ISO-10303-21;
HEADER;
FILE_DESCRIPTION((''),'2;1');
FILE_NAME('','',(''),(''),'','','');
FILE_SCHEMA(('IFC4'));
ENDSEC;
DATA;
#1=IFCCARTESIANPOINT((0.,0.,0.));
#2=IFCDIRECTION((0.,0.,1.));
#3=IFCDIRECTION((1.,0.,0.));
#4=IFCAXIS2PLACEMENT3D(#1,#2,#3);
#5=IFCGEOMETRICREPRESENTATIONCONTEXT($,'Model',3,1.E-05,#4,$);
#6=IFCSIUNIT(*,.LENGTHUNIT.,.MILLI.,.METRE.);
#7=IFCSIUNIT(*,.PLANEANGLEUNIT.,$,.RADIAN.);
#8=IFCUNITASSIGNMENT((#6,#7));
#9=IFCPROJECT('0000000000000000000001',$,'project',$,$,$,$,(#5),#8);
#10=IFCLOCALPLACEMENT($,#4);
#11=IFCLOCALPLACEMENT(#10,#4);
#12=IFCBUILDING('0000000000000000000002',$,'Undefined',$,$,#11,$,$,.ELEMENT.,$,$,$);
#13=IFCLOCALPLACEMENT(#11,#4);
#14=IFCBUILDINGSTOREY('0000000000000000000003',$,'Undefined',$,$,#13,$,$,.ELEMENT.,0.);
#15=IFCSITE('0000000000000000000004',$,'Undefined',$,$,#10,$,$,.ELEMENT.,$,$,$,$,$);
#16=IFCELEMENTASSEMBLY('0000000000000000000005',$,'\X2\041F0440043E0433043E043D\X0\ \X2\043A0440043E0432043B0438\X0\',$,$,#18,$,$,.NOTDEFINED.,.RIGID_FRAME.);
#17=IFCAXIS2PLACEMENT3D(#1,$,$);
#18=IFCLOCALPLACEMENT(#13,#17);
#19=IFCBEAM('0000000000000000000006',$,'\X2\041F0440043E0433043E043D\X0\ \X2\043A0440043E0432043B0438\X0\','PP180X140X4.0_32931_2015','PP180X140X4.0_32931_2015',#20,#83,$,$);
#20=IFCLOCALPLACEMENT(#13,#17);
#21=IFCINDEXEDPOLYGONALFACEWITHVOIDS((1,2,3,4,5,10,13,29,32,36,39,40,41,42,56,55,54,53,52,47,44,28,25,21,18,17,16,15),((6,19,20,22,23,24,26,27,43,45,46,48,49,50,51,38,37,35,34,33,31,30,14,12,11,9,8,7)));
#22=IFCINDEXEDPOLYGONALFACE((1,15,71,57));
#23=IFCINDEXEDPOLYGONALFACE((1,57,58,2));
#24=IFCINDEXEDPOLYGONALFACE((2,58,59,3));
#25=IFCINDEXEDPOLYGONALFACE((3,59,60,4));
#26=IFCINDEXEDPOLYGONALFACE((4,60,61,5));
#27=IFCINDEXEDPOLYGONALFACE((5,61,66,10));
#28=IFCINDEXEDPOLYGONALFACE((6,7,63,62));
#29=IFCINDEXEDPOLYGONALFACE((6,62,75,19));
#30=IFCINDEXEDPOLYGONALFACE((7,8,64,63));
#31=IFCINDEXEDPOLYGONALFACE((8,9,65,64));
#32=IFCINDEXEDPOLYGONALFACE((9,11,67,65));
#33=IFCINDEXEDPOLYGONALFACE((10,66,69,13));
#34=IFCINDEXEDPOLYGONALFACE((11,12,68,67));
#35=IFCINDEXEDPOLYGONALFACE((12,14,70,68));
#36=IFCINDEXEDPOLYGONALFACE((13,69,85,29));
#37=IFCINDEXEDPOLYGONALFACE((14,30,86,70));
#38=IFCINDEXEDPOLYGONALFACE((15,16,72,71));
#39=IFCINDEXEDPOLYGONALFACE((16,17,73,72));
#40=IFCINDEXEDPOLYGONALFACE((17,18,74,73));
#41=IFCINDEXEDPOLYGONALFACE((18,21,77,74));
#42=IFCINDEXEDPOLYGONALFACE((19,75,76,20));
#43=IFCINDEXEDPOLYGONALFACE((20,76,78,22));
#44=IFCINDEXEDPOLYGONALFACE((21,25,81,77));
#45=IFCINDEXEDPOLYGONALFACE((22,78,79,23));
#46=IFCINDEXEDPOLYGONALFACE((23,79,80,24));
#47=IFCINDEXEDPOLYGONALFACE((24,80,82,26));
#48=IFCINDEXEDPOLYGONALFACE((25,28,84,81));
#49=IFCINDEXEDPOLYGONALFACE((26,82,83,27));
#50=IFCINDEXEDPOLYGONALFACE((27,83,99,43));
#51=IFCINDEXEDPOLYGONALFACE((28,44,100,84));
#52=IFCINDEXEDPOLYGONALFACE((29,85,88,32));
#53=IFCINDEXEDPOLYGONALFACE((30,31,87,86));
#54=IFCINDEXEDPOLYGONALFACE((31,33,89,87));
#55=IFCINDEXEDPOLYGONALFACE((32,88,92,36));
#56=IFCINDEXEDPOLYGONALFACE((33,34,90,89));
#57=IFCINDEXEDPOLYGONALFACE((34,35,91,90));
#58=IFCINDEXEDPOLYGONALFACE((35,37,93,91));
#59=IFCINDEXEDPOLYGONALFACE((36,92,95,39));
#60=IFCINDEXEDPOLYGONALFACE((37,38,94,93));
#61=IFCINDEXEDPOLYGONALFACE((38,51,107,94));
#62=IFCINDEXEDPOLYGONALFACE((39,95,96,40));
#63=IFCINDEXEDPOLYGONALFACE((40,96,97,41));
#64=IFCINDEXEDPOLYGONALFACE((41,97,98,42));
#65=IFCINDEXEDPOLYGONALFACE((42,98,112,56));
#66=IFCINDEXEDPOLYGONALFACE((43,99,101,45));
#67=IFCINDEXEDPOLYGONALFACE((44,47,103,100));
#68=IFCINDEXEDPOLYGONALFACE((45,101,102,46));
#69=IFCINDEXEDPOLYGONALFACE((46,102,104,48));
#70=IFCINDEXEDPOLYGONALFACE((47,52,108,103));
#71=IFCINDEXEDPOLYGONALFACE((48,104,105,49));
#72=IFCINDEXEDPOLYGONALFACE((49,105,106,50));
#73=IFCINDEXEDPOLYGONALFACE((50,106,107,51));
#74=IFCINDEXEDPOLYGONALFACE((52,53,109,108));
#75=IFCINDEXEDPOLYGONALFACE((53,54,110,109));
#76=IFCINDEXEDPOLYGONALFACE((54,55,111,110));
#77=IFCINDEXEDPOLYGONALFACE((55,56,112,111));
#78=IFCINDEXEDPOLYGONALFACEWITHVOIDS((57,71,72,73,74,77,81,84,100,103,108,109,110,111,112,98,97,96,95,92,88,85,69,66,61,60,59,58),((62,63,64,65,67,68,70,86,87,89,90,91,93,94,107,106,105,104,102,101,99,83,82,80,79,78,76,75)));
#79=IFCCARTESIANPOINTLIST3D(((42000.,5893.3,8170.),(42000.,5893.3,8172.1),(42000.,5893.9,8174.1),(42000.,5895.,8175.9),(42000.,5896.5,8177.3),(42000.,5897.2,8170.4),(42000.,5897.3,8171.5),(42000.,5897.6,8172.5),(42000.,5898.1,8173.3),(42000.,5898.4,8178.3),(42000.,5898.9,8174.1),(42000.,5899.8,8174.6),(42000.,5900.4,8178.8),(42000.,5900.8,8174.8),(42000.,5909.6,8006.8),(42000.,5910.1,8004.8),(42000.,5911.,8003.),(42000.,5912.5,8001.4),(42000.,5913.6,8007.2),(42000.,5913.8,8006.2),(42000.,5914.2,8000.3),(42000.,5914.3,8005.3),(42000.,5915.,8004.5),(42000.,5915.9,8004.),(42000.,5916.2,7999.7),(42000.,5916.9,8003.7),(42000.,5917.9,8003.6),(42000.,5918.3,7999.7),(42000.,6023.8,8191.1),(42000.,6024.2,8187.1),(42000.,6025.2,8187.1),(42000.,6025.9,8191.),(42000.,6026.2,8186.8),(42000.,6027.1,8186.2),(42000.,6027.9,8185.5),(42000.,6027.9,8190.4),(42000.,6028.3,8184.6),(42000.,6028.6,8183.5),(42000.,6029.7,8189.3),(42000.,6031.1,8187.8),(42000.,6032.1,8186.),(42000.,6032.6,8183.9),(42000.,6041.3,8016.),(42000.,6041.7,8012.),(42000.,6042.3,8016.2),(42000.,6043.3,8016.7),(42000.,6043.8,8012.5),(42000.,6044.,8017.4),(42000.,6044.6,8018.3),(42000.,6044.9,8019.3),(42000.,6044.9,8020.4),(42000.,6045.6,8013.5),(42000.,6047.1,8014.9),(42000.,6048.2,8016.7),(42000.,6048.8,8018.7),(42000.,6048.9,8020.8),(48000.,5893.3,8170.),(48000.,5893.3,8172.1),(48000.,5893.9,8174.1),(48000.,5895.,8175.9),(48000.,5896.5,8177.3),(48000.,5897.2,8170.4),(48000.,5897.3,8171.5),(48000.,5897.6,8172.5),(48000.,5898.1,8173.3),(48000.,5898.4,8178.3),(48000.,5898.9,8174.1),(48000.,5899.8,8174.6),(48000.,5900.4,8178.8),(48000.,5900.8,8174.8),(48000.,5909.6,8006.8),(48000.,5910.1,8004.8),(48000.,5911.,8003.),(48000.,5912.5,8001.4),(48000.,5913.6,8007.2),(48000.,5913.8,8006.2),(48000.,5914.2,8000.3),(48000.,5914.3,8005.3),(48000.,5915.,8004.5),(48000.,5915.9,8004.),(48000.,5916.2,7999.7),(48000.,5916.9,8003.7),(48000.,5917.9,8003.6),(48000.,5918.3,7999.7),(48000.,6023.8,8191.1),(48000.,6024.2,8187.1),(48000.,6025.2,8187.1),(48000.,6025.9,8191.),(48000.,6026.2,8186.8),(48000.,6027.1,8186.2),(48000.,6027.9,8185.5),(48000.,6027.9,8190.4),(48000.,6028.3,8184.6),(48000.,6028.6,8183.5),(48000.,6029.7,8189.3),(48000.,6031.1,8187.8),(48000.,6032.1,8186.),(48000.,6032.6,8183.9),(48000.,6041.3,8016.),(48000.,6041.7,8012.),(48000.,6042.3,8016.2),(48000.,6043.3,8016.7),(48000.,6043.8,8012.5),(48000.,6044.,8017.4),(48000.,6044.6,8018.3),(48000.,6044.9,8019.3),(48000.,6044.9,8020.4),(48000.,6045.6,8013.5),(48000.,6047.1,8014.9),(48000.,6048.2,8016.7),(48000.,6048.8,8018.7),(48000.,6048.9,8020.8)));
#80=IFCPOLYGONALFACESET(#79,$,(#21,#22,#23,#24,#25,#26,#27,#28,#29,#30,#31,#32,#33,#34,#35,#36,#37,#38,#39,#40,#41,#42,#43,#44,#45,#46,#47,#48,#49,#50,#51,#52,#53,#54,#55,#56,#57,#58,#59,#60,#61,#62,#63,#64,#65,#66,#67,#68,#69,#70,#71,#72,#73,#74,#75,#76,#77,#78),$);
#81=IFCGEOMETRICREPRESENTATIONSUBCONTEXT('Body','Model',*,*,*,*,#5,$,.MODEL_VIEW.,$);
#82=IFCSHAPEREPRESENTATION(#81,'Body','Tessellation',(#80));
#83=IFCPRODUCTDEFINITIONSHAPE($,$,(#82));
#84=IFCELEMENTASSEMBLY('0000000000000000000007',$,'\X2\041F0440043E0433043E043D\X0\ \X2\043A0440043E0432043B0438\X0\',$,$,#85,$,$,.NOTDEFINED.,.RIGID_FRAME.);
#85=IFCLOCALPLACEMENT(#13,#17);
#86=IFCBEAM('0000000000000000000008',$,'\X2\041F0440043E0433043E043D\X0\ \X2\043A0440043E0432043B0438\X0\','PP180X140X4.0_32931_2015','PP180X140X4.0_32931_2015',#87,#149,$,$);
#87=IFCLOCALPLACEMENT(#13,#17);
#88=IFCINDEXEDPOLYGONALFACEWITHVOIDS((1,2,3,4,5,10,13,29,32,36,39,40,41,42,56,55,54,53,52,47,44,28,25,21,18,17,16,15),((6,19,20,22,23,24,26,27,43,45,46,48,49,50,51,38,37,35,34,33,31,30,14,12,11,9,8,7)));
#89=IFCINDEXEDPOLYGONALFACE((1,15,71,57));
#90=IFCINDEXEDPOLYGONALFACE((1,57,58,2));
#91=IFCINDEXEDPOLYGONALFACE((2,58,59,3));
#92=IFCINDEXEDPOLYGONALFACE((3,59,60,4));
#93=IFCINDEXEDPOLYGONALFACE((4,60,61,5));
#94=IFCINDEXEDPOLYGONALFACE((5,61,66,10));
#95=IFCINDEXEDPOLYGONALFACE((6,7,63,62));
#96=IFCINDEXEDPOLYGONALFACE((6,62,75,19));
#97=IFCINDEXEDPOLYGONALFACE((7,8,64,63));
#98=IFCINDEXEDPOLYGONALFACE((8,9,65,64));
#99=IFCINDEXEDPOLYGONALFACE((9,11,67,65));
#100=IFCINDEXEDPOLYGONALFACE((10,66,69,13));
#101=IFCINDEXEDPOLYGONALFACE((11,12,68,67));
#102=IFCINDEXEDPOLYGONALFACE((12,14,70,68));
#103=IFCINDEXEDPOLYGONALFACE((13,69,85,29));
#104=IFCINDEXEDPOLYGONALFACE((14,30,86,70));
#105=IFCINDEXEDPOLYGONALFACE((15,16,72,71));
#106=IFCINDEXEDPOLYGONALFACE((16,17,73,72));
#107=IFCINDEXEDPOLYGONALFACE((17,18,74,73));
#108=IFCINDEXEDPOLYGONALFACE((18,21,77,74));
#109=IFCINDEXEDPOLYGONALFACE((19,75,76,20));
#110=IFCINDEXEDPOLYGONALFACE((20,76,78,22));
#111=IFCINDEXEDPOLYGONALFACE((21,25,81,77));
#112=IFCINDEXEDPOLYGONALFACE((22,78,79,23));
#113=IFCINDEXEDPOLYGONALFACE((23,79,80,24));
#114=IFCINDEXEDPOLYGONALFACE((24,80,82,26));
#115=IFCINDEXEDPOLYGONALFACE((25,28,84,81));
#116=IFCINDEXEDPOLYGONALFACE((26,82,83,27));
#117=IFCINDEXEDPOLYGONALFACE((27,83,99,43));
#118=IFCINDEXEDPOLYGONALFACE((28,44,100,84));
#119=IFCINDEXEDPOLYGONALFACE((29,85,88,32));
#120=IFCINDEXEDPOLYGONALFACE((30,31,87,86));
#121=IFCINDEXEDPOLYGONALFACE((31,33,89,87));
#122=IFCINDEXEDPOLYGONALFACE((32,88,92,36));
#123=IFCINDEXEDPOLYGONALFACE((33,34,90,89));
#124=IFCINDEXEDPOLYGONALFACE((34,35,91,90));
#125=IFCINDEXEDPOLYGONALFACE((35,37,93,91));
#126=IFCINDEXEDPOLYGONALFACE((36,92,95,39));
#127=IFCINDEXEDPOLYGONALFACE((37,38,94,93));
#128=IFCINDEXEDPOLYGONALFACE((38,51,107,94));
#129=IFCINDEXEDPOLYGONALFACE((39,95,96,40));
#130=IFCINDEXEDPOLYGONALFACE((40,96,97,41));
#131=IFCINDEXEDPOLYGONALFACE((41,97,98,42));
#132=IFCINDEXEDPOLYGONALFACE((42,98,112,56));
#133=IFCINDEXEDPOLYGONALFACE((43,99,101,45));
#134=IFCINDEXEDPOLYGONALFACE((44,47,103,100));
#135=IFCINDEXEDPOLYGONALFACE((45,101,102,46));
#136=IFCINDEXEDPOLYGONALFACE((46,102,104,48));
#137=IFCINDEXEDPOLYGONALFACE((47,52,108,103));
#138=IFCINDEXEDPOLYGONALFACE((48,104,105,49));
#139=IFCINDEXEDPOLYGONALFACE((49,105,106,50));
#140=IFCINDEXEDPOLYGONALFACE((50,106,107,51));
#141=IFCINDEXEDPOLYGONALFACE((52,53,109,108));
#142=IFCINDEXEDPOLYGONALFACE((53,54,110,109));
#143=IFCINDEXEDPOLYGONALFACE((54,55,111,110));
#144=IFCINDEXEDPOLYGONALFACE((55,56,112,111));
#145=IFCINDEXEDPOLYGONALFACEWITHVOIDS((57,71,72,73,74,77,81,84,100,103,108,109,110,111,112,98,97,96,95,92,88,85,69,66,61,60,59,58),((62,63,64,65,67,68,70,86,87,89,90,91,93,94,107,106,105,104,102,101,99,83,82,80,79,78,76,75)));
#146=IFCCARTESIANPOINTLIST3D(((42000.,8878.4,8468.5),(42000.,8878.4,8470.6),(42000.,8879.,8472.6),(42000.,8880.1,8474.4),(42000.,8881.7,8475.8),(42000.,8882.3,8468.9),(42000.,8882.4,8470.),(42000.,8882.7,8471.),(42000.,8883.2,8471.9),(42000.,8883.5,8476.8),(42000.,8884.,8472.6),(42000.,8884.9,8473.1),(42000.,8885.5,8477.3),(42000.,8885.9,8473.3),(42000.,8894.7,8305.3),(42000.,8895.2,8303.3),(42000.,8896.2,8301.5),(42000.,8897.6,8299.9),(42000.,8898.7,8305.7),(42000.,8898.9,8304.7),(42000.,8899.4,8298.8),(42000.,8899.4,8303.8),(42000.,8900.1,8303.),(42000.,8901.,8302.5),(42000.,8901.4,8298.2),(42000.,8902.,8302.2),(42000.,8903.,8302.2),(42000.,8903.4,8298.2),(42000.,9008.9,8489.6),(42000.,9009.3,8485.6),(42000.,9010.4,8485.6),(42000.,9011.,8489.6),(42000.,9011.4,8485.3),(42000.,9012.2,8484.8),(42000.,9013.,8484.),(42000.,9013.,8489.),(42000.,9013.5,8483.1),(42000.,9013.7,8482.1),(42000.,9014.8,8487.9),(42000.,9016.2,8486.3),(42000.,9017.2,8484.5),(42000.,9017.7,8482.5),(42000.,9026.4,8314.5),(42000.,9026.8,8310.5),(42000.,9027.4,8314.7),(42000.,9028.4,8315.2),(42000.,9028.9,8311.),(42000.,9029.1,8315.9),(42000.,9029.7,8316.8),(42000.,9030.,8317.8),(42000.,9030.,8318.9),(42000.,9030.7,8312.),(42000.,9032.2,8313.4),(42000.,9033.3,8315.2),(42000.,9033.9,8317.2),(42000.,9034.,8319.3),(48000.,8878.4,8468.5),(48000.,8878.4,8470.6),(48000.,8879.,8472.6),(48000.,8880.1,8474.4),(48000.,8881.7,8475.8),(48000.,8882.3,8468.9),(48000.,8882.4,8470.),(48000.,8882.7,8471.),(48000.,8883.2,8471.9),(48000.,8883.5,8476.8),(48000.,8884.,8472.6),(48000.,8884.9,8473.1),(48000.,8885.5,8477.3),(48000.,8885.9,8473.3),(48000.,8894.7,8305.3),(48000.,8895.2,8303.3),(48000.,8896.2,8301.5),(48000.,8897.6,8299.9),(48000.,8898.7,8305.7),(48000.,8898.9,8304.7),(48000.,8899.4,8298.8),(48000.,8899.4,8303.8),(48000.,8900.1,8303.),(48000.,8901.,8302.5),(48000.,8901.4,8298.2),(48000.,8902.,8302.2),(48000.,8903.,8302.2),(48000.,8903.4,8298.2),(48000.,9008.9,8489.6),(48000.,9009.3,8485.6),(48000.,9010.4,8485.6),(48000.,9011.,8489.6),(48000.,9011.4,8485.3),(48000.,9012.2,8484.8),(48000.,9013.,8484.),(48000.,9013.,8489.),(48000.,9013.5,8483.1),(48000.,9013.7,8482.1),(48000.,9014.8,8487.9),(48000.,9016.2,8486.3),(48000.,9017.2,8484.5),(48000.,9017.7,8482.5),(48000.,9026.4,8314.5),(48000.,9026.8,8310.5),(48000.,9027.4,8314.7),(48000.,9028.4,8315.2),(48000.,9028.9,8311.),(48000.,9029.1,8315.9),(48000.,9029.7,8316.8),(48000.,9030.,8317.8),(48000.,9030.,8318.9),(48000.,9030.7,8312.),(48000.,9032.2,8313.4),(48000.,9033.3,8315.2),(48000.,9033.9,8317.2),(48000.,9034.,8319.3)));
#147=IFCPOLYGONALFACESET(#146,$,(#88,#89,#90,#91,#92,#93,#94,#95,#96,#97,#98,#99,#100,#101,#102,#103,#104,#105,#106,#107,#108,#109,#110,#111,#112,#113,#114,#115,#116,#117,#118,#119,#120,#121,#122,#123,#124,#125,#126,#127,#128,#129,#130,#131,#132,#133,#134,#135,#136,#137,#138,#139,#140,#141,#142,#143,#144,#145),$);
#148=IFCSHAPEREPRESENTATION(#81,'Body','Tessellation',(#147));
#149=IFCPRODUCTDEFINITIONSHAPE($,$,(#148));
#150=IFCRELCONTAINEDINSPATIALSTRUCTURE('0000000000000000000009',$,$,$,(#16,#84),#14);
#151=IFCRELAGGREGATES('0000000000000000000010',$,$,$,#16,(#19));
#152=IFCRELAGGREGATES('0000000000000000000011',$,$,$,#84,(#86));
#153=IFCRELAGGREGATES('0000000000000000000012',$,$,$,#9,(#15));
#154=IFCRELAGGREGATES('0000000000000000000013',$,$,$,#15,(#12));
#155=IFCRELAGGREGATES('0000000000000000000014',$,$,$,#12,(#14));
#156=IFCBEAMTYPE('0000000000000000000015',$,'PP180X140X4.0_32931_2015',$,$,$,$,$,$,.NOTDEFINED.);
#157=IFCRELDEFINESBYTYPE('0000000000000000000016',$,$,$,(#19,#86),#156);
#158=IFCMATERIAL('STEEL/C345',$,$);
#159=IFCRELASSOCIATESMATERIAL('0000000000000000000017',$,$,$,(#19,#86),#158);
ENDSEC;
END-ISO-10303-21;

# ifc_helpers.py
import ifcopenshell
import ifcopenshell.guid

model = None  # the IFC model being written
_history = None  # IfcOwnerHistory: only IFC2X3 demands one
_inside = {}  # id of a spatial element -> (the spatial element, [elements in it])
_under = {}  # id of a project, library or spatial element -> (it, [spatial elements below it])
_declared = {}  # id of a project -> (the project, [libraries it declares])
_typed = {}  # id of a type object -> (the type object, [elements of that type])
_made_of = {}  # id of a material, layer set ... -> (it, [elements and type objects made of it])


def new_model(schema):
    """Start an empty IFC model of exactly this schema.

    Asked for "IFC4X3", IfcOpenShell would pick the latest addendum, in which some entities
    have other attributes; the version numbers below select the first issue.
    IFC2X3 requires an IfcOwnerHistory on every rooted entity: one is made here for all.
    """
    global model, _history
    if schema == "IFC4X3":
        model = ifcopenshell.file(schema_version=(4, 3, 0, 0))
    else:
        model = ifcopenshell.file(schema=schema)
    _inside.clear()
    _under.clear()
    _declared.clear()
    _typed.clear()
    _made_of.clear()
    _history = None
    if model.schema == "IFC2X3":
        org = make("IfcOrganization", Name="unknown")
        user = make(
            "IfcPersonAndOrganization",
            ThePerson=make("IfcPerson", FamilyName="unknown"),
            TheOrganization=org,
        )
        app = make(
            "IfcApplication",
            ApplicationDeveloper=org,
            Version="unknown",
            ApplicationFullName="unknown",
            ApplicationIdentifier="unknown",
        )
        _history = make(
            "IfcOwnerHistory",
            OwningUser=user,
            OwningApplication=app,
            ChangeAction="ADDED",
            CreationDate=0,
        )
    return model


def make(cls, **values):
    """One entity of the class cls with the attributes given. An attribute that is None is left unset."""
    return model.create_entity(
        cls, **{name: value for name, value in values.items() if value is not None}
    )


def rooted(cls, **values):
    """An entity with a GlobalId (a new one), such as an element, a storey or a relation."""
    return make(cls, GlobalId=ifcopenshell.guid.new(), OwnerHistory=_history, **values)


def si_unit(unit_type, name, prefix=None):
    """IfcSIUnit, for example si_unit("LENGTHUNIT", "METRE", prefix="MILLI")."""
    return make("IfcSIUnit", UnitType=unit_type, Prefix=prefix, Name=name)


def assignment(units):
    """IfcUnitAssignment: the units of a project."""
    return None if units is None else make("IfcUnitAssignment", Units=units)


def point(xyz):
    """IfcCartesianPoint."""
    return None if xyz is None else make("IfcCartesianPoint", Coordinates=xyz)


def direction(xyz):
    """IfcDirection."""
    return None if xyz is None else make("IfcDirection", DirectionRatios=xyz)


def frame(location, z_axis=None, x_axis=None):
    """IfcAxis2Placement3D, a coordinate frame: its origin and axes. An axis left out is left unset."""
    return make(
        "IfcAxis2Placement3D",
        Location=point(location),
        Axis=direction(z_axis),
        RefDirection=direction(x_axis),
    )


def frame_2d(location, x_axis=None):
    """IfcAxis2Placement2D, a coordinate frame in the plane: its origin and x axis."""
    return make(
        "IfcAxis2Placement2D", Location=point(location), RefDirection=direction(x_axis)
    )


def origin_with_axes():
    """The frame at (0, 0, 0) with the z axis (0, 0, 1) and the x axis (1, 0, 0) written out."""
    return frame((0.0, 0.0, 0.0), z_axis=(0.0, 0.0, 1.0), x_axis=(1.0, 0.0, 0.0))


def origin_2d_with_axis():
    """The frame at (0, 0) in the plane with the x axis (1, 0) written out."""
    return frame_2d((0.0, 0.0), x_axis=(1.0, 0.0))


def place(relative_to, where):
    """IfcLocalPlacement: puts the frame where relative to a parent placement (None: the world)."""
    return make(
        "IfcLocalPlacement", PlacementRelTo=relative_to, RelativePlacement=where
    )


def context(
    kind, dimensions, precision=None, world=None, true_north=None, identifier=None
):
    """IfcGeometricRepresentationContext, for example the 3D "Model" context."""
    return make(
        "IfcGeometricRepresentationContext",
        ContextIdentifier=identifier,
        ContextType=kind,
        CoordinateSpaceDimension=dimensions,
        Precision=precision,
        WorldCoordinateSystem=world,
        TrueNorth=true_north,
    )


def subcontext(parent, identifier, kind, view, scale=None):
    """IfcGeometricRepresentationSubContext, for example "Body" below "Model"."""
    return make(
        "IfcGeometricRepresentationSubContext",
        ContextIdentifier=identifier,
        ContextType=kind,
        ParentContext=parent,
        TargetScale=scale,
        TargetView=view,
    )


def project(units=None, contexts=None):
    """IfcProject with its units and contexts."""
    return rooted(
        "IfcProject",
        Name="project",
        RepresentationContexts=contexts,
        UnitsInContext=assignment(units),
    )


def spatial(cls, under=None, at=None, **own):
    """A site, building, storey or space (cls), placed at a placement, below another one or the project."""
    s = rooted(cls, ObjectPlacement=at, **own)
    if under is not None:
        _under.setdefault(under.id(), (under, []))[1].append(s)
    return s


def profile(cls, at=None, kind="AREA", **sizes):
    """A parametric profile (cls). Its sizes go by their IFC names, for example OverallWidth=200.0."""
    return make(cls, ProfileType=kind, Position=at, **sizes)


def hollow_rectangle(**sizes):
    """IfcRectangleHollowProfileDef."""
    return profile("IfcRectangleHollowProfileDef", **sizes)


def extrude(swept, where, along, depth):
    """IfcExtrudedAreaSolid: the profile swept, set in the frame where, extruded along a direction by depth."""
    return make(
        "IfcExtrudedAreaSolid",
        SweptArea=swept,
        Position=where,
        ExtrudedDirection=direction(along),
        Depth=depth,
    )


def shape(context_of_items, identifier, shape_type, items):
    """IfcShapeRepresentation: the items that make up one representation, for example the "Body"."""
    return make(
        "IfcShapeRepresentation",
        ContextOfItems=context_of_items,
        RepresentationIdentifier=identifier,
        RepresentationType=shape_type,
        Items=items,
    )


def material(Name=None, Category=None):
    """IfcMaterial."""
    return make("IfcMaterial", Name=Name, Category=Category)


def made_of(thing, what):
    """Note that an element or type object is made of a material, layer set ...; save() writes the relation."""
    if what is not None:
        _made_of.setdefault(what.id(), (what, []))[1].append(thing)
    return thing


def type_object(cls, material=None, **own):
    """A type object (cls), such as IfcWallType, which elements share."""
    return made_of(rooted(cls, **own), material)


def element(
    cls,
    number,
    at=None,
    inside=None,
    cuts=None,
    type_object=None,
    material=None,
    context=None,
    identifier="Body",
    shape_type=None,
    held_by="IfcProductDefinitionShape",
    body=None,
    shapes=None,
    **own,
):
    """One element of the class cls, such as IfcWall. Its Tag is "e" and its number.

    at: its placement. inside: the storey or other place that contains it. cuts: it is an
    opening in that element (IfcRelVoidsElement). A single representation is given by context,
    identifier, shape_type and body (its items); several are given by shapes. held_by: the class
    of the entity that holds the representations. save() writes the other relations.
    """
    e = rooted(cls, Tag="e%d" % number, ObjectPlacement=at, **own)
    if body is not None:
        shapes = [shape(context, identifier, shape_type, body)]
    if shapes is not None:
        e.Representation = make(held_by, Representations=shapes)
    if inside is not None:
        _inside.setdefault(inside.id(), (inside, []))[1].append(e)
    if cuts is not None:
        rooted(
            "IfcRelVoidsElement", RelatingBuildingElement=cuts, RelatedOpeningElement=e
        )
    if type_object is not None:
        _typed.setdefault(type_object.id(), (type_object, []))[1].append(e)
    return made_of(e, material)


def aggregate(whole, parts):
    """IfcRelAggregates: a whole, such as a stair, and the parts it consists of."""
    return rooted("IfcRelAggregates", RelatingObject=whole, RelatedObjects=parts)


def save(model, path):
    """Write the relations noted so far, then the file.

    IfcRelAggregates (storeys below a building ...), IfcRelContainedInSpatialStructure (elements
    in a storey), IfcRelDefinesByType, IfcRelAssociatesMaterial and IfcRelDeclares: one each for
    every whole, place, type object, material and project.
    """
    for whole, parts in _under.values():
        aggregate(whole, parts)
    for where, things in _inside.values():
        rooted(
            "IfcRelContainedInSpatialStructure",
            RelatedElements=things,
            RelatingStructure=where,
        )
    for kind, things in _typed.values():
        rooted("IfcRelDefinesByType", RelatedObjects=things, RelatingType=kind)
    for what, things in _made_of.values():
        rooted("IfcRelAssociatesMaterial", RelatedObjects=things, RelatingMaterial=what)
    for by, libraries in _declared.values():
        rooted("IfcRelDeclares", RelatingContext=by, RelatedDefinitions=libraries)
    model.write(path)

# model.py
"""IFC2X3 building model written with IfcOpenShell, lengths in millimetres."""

from ifc_helpers import new_model, si_unit, frame, origin_with_axes, origin_2d_with_axis, place, context, subcontext, project, spatial, hollow_rectangle, extrude, material, type_object, element, aggregate, save


model = new_model("IFC2X3")

# Units and contexts
model_context = context("Model", 3, precision=1e-05, world=origin_with_axes())
body_context = subcontext(model_context, "Body", "Model", "MODEL_VIEW")
ifc_project = project(units=[si_unit("LENGTHUNIT", "METRE", prefix="MILLI"), si_unit("PLANEANGLEUNIT", "RADIAN")], contexts=[model_context])

# Site, building, storey
site_placement = place(None, origin_with_axes())
site = spatial("IfcSite", under=ifc_project, at=site_placement, Name="Undefined", CompositionType="ELEMENT")
building_placement = place(site_placement, origin_with_axes())
building = spatial("IfcBuilding", under=site, at=building_placement, Name="Undefined", CompositionType="ELEMENT")
storey_placement = place(building_placement, origin_with_axes())
storey = spatial("IfcBuildingStorey", under=building, at=storey_placement, Name="Undefined", CompositionType="ELEMENT", Elevation=0.0)

# Element assemblies, beams
ifc_material_1 = material(Name="STEEL/C345")
beam_type_1 = type_object("IfcBeamType", Name="PP180X140X4.0_32931_2015", PredefinedType="NOTDEFINED")
assembly_1_placement = place(storey_placement, origin_with_axes())
assembly_1 = element("IfcElementAssembly", 1, at=assembly_1_placement, inside=storey, Name="Прогон кровли", AssemblyPlace="NOTDEFINED", PredefinedType="RIGID_FRAME")
beam_1_placement = place(assembly_1_placement, frame((42000.0, 5971.1, 8095.4), z_axis=(0.0, -0.099504, 0.995037), x_axis=(1.0, 0.0, 0.0)))
beam_1 = element("IfcBeam", 2, at=beam_1_placement, type_object=beam_type_1, material=ifc_material_1, Name="Прогон кровли", Description="PP180X140X4.0_32931_2015", ObjectType="PP180X140X4.0_32931_2015", context=body_context, shape_type="SweptSolid", body=[
    extrude(hollow_rectangle(XDim=140.0, YDim=180.0, WallThickness=4.0, InnerFilletRadius=4.0, OuterFilletRadius=8.0, at=origin_2d_with_axis()), frame((6000.0, 0.0, 0.0), z_axis=(-1.0, 0.0, 0.0), x_axis=(0.0, -1.0, 0.0)), (0.0, 0.0, 1.0), 6000.0),
])
aggregate(assembly_1, [beam_1])
assembly_2_placement = place(storey_placement, origin_with_axes())
assembly_2 = element("IfcElementAssembly", 3, at=assembly_2_placement, inside=storey, Name="Прогон кровли", AssemblyPlace="NOTDEFINED", PredefinedType="RIGID_FRAME")
beam_2_placement = place(assembly_2_placement, frame((42000.0, 8956.2, 8393.9), z_axis=(0.0, -0.099504, 0.995037), x_axis=(1.0, 0.0, 0.0)))
beam_2 = element("IfcBeam", 4, at=beam_2_placement, type_object=beam_type_1, material=ifc_material_1, Name="Прогон кровли", Description="PP180X140X4.0_32931_2015", ObjectType="PP180X140X4.0_32931_2015", context=body_context, shape_type="SweptSolid", body=[
    extrude(hollow_rectangle(XDim=140.0, YDim=180.0, WallThickness=4.0, InnerFilletRadius=4.0, OuterFilletRadius=8.0, at=origin_2d_with_axis()), frame((6000.0, 0.0, 0.0), z_axis=(-1.0, 0.0, 0.0), x_axis=(0.0, -1.0, 0.0)), (0.0, 0.0, 1.0), 6000.0),
])
aggregate(assembly_2, [beam_2])

save(model, "model.ifc")
